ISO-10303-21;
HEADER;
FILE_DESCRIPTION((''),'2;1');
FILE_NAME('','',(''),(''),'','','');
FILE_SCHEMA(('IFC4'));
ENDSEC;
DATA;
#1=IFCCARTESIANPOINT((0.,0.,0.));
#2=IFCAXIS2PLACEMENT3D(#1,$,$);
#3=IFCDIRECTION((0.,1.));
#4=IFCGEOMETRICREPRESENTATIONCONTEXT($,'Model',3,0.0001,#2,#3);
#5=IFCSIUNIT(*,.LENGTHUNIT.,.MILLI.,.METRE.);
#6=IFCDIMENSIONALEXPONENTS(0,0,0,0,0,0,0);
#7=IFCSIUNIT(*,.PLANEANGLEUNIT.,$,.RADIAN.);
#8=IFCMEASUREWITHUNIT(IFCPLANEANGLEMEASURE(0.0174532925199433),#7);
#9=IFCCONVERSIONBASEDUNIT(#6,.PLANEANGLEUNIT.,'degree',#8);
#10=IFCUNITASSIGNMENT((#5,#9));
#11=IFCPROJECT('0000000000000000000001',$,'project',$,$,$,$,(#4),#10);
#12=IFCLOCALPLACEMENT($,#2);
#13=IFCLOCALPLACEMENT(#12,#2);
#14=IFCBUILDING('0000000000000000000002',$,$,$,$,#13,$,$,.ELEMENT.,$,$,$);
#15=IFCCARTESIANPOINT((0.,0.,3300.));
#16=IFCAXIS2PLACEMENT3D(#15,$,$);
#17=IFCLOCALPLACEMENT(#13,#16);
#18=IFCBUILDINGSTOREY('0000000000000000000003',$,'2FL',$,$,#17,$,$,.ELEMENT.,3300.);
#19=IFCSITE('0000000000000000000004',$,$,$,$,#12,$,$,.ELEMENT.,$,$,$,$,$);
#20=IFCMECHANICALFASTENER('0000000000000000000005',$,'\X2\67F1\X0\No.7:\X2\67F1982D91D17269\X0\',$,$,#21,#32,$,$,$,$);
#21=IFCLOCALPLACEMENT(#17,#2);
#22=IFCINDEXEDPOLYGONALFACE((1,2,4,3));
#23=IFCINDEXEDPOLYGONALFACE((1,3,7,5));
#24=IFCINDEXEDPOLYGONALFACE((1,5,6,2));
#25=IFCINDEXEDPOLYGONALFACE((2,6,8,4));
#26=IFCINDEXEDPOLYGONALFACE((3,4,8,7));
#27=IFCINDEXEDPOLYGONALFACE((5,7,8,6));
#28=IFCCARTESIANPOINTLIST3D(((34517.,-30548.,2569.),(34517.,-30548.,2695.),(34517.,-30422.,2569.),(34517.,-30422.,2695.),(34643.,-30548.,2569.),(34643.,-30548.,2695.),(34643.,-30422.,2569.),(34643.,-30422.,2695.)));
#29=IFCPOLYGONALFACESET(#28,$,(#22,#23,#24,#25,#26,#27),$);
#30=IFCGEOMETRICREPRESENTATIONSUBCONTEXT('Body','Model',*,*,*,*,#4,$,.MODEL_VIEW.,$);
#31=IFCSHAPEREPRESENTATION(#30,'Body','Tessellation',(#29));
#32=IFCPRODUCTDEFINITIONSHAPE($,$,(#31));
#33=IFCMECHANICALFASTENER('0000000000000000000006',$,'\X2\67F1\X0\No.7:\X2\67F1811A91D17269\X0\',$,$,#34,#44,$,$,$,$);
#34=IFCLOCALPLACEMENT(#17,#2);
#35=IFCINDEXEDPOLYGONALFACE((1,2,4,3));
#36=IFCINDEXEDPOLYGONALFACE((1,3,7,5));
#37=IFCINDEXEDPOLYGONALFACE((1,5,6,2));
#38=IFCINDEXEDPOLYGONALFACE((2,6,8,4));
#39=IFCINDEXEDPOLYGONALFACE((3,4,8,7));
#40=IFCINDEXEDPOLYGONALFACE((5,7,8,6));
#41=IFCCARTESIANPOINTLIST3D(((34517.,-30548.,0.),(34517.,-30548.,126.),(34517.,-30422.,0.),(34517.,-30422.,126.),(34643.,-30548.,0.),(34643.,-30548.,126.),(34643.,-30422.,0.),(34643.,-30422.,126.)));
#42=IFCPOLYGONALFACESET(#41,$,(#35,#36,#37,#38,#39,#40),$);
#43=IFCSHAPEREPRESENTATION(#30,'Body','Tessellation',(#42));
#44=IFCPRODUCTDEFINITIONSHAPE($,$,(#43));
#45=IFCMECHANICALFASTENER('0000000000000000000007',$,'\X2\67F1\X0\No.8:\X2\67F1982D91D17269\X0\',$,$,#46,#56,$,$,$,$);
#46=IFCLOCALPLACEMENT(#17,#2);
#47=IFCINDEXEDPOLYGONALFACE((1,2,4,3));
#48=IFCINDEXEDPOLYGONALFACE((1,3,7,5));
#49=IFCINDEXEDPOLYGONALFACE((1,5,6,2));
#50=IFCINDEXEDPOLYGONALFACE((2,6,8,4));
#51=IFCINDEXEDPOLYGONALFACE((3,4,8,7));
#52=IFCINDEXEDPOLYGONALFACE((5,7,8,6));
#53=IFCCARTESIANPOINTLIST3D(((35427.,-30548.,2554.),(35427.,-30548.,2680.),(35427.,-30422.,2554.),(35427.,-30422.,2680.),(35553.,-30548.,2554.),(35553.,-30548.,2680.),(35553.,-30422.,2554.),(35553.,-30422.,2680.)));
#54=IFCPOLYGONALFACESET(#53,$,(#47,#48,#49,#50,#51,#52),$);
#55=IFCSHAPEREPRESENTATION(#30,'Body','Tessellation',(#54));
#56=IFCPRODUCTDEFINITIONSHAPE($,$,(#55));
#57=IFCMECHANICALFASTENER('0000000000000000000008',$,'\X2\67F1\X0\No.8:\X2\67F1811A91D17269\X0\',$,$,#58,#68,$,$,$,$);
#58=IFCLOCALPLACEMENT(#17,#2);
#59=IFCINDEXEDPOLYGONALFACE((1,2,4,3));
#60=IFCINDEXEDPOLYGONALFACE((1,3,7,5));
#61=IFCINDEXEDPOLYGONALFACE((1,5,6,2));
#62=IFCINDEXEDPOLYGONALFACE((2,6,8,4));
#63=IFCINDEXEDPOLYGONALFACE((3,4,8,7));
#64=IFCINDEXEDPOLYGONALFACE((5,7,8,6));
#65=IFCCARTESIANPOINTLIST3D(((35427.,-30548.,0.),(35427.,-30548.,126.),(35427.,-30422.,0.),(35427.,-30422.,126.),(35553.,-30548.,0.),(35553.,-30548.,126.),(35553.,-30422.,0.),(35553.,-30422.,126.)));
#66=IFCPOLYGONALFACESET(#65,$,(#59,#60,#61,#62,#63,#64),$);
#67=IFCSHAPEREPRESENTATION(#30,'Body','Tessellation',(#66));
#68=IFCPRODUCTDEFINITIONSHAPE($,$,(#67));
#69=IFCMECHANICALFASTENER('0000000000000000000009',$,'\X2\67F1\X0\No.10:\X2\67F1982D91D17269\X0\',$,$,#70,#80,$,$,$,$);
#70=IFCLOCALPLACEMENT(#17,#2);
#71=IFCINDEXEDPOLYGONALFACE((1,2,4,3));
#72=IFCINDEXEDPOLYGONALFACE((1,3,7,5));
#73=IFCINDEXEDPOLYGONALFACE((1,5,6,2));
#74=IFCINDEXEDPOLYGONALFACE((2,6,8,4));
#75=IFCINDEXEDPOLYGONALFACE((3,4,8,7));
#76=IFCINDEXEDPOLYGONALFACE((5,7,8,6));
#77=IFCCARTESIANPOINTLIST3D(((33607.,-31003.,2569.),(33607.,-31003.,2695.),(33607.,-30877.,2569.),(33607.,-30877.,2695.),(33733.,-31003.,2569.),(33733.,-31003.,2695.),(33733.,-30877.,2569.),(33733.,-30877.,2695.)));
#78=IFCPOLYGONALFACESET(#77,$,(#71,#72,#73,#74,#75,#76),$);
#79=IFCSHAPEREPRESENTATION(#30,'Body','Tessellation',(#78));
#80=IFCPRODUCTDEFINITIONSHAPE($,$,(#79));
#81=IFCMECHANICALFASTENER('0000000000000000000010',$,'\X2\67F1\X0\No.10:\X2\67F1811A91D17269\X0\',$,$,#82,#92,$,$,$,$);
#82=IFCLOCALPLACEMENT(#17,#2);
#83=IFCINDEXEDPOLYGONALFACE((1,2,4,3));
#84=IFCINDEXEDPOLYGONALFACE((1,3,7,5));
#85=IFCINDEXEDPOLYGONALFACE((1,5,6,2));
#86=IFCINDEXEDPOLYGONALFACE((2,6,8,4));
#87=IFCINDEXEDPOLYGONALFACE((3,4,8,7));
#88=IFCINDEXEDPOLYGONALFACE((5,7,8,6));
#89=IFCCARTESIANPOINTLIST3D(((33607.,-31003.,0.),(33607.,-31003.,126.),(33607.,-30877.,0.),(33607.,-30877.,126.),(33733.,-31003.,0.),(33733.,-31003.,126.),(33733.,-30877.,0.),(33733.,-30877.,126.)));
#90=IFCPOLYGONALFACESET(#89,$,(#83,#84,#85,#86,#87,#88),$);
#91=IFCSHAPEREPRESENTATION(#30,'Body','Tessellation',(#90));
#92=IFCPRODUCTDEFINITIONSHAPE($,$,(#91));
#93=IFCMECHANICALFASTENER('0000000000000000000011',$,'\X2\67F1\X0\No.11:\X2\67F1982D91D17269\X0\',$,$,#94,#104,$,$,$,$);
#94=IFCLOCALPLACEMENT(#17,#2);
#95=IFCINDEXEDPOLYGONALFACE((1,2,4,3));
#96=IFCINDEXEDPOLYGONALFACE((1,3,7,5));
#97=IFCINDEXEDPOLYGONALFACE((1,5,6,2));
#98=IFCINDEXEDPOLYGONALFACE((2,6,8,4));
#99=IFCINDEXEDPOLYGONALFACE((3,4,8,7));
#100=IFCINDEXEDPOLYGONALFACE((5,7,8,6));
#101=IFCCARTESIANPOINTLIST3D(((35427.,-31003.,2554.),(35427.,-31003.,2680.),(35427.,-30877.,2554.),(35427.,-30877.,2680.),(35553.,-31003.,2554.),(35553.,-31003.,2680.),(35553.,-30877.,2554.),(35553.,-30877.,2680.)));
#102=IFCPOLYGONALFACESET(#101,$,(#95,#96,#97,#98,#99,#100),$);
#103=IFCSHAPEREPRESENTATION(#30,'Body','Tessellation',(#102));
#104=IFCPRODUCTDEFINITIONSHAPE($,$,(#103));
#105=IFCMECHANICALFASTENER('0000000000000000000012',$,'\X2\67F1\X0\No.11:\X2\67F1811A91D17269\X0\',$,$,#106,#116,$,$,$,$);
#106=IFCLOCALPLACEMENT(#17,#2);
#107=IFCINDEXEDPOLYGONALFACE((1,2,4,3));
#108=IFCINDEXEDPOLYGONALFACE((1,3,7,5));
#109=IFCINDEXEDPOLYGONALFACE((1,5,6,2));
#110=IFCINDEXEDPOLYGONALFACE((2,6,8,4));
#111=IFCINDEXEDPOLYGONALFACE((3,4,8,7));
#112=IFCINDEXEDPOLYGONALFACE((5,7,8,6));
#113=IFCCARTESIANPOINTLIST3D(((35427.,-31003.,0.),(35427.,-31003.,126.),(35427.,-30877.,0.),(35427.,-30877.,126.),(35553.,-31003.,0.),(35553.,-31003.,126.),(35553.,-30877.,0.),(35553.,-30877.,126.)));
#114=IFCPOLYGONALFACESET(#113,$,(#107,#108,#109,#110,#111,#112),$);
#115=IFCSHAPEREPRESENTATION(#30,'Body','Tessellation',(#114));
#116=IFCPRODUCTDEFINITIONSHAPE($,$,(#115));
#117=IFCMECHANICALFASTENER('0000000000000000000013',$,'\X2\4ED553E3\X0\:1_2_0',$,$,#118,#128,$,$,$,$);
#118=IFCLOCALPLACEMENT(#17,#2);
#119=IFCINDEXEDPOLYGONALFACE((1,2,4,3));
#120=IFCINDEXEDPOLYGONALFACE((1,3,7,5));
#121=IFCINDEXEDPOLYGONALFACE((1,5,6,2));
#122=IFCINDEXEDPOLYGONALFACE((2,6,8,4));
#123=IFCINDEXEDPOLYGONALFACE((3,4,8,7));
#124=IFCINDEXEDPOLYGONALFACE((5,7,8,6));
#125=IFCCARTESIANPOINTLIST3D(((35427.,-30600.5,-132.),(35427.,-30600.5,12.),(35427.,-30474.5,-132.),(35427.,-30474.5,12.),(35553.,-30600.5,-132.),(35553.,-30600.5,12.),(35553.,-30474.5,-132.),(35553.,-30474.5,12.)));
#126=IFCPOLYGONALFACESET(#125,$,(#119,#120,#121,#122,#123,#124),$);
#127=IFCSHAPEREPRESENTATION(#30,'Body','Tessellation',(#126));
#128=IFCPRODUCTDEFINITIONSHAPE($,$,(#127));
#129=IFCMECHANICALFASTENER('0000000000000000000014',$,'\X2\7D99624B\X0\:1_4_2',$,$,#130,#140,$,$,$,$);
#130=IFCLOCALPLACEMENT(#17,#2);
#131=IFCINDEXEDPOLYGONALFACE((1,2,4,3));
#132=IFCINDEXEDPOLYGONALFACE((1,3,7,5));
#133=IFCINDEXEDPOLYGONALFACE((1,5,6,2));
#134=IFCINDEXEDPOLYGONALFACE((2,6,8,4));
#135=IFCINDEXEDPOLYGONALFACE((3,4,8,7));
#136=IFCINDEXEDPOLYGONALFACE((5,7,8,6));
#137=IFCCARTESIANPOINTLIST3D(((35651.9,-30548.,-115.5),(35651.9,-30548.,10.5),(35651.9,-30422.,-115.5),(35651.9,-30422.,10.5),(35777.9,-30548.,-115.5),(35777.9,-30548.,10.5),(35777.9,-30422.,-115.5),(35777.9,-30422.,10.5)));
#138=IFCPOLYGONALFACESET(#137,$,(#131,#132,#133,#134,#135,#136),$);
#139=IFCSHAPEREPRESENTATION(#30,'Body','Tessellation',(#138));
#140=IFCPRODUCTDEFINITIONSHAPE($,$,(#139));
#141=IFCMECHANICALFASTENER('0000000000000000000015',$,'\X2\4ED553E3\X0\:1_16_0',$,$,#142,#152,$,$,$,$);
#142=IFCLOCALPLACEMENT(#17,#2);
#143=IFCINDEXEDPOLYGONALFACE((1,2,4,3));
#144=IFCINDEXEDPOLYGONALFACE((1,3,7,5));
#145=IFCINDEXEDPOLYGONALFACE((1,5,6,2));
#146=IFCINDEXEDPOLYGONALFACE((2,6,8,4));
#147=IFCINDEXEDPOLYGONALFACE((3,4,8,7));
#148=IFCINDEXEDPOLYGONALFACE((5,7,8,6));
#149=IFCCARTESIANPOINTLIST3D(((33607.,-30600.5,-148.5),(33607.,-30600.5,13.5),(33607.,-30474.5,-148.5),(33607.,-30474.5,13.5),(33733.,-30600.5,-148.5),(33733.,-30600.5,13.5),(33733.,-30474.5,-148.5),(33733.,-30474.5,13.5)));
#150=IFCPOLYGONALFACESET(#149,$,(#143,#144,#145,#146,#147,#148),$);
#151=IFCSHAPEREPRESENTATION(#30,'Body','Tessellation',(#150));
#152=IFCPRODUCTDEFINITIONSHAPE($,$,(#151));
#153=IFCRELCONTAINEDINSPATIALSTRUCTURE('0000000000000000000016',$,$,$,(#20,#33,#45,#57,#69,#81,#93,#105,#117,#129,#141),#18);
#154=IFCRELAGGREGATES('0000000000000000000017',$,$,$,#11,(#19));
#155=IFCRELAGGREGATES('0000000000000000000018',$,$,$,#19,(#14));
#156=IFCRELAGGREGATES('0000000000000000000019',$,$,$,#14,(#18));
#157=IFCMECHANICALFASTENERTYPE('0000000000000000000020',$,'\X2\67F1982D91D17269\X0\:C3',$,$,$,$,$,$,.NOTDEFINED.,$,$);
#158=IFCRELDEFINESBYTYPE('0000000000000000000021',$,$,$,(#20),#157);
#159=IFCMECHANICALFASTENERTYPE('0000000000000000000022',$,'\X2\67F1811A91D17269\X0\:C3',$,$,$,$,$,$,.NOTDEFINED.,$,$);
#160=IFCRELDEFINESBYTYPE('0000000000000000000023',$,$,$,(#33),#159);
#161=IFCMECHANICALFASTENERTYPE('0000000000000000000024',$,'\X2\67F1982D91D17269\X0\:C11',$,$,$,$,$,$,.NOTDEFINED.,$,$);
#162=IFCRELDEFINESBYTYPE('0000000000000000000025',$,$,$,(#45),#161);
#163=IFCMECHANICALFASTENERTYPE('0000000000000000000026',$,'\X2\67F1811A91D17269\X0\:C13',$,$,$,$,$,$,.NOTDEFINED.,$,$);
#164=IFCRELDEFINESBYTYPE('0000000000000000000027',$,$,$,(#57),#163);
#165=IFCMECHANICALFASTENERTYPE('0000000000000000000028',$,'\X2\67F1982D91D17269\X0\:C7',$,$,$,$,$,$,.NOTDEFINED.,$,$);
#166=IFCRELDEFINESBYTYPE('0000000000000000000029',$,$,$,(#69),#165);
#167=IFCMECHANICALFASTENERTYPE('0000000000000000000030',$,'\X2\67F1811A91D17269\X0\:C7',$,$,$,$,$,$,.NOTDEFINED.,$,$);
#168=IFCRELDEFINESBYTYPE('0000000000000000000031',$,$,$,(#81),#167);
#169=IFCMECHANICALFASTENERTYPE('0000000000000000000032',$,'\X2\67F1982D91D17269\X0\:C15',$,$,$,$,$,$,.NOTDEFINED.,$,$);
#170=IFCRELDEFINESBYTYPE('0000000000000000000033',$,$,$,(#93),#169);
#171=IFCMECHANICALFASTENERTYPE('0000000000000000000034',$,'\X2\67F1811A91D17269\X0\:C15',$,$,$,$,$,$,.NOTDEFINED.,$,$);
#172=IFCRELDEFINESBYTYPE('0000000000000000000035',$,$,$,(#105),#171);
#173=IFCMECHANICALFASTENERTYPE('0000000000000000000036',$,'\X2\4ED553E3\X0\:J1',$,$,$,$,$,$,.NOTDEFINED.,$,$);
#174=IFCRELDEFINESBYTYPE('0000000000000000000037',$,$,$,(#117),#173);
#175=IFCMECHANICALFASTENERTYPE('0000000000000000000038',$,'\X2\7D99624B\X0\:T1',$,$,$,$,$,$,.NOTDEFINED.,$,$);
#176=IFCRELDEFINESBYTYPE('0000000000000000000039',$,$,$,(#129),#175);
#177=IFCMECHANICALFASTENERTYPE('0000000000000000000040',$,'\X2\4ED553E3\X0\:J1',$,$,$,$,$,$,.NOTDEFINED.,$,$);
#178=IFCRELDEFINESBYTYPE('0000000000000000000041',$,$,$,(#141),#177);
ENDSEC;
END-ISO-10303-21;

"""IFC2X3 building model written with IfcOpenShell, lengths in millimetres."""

from ifc_helpers import new_model, entity, si_unit, converted_unit, direction, frame, origin, origin_with_axes, origin_2d, place, context, subcontext, project, spatial, rectangle, extrude, type_object, element, save


model = new_model("IFC2X3")

# Units and contexts
model_context = context("Model", 3, precision=0.0001, world=origin(), true_north=direction((0.0, 1.0)))
body_context = subcontext(model_context, "Body", "Model", "MODEL_VIEW")
ifc_project = project(units=[si_unit("LENGTHUNIT", "METRE", prefix="MILLI"), converted_unit("PLANEANGLEUNIT", "degree", entity("IfcPlaneAngleMeasure", 0.0174532925199433), si_unit("PLANEANGLEUNIT", "RADIAN"), dimensions=[0, 0, 0, 0, 0, 0, 0])], contexts=[model_context])

# Site, building, storey
site_placement = place(None, origin())
site = spatial("IfcSite", under=ifc_project, at=site_placement, CompositionType="ELEMENT")
building_placement = place(site_placement, origin())
building = spatial("IfcBuilding", under=site, at=building_placement, CompositionType="ELEMENT")
storey_placement = place(building_placement, frame((0.0, 0.0, 3300.0)))
storey = spatial("IfcBuildingStorey", under=building, at=storey_placement, Name="2FL", CompositionType="ELEMENT", Elevation=3300.0)

# Mechanical fasteners
mechanical_fastener_type_1 = type_object("IfcMechanicalFastenerType", Name="柱頭金物:C3")
mechanical_fastener_1_placement = place(storey_placement, frame((34580.0, -30485.0, 2569.0)))
element("IfcMechanicalFastener", 1, at=mechanical_fastener_1_placement, inside=storey, type_object=mechanical_fastener_type_1, Name="柱No.7:柱頭金物", context=body_context, shape_type="SweptSolid", body=[
    extrude(rectangle(XDim=126.0, YDim=126.0, at=origin_2d()), origin_with_axes(), (0.0, 0.0, 1.0), 126.0),
])
mechanical_fastener_type_2 = type_object("IfcMechanicalFastenerType", Name="柱脚金物:C3")
mechanical_fastener_2_placement = place(storey_placement, frame((34580.0, -30485.0, 0.0)))
element("IfcMechanicalFastener", 2, at=mechanical_fastener_2_placement, inside=storey, type_object=mechanical_fastener_type_2, Name="柱No.7:柱脚金物", context=body_context, shape_type="SweptSolid", body=[
    extrude(rectangle(XDim=126.0, YDim=126.0, at=origin_2d()), origin_with_axes(), (0.0, 0.0, 1.0), 126.0),
])
mechanical_fastener_type_3 = type_object("IfcMechanicalFastenerType", Name="柱頭金物:C11")
mechanical_fastener_3_placement = place(storey_placement, frame((35490.0, -30485.0, 2554.0)))
element("IfcMechanicalFastener", 3, at=mechanical_fastener_3_placement, inside=storey, type_object=mechanical_fastener_type_3, Name="柱No.8:柱頭金物", context=body_context, shape_type="SweptSolid", body=[
    extrude(rectangle(XDim=126.0, YDim=126.0, at=origin_2d()), origin_with_axes(), (0.0, 0.0, 1.0), 126.0),
])
mechanical_fastener_type_4 = type_object("IfcMechanicalFastenerType", Name="柱脚金物:C13")
mechanical_fastener_4_placement = place(storey_placement, frame((35490.0, -30485.0, 0.0)))
element("IfcMechanicalFastener", 4, at=mechanical_fastener_4_placement, inside=storey, type_object=mechanical_fastener_type_4, Name="柱No.8:柱脚金物", context=body_context, shape_type="SweptSolid", body=[
    extrude(rectangle(XDim=126.0, YDim=126.0, at=origin_2d()), origin_with_axes(), (0.0, 0.0, 1.0), 126.0),
])
mechanical_fastener_type_5 = type_object("IfcMechanicalFastenerType", Name="柱頭金物:C7")
mechanical_fastener_5_placement = place(storey_placement, frame((33670.0, -30940.0, 2569.0)))
element("IfcMechanicalFastener", 5, at=mechanical_fastener_5_placement, inside=storey, type_object=mechanical_fastener_type_5, Name="柱No.10:柱頭金物", context=body_context, shape_type="SweptSolid", body=[
    extrude(rectangle(XDim=126.0, YDim=126.0, at=origin_2d()), origin_with_axes(), (0.0, 0.0, 1.0), 126.0),
])
mechanical_fastener_type_6 = type_object("IfcMechanicalFastenerType", Name="柱脚金物:C7")
mechanical_fastener_6_placement = place(storey_placement, frame((33670.0, -30940.0, 0.0)))
element("IfcMechanicalFastener", 6, at=mechanical_fastener_6_placement, inside=storey, type_object=mechanical_fastener_type_6, Name="柱No.10:柱脚金物", context=body_context, shape_type="SweptSolid", body=[
    extrude(rectangle(XDim=126.0, YDim=126.0, at=origin_2d()), origin_with_axes(), (0.0, 0.0, 1.0), 126.0),
])
mechanical_fastener_type_7 = type_object("IfcMechanicalFastenerType", Name="柱頭金物:C15")
mechanical_fastener_7_placement = place(storey_placement, frame((35490.0, -30940.0, 2554.0)))
element("IfcMechanicalFastener", 7, at=mechanical_fastener_7_placement, inside=storey, type_object=mechanical_fastener_type_7, Name="柱No.11:柱頭金物", context=body_context, shape_type="SweptSolid", body=[
    extrude(rectangle(XDim=126.0, YDim=126.0, at=origin_2d()), origin_with_axes(), (0.0, 0.0, 1.0), 126.0),
])
mechanical_fastener_type_8 = type_object("IfcMechanicalFastenerType", Name="柱脚金物:C15")
mechanical_fastener_8_placement = place(storey_placement, frame((35490.0, -30940.0, 0.0)))
element("IfcMechanicalFastener", 8, at=mechanical_fastener_8_placement, inside=storey, type_object=mechanical_fastener_type_8, Name="柱No.11:柱脚金物", context=body_context, shape_type="SweptSolid", body=[
    extrude(rectangle(XDim=126.0, YDim=126.0, at=origin_2d()), origin_with_axes(), (0.0, 0.0, 1.0), 126.0),
])
mechanical_fastener_type_9 = type_object("IfcMechanicalFastenerType", Name="仕口:J1")
mechanical_fastener_9_placement = place(storey_placement, frame((35490.0, -30537.5, -132.0)))
element("IfcMechanicalFastener", 9, at=mechanical_fastener_9_placement, inside=storey, type_object=mechanical_fastener_type_9, Name="仕口:1_2_0", context=body_context, shape_type="SweptSolid", body=[
    extrude(rectangle(XDim=126.0, YDim=126.0, at=origin_2d()), origin_with_axes(), (0.0, 0.0, 1.0), 144.0),
])
mechanical_fastener_type_10 = type_object("IfcMechanicalFastenerType", Name="継手:T1")
mechanical_fastener_10_placement = place(storey_placement, frame((35714.9, -30485.0, -115.5)))
element("IfcMechanicalFastener", 10, at=mechanical_fastener_10_placement, inside=storey, type_object=mechanical_fastener_type_10, Name="継手:1_4_2", context=body_context, shape_type="SweptSolid", body=[
    extrude(rectangle(XDim=126.0, YDim=126.0, at=origin_2d()), origin_with_axes(), (0.0, 0.0, 1.0), 126.0),
])
mechanical_fastener_type_11 = type_object("IfcMechanicalFastenerType", Name="仕口:J1")
mechanical_fastener_11_placement = place(storey_placement, frame((33670.0, -30537.5, -148.5)))
element("IfcMechanicalFastener", 11, at=mechanical_fastener_11_placement, inside=storey, type_object=mechanical_fastener_type_11, Name="仕口:1_16_0", context=body_context, shape_type="SweptSolid", body=[
    extrude(rectangle(XDim=126.0, YDim=126.0, at=origin_2d()), origin_with_axes(), (0.0, 0.0, 1.0), 162.0),
])

save(model, "model.ifc")
